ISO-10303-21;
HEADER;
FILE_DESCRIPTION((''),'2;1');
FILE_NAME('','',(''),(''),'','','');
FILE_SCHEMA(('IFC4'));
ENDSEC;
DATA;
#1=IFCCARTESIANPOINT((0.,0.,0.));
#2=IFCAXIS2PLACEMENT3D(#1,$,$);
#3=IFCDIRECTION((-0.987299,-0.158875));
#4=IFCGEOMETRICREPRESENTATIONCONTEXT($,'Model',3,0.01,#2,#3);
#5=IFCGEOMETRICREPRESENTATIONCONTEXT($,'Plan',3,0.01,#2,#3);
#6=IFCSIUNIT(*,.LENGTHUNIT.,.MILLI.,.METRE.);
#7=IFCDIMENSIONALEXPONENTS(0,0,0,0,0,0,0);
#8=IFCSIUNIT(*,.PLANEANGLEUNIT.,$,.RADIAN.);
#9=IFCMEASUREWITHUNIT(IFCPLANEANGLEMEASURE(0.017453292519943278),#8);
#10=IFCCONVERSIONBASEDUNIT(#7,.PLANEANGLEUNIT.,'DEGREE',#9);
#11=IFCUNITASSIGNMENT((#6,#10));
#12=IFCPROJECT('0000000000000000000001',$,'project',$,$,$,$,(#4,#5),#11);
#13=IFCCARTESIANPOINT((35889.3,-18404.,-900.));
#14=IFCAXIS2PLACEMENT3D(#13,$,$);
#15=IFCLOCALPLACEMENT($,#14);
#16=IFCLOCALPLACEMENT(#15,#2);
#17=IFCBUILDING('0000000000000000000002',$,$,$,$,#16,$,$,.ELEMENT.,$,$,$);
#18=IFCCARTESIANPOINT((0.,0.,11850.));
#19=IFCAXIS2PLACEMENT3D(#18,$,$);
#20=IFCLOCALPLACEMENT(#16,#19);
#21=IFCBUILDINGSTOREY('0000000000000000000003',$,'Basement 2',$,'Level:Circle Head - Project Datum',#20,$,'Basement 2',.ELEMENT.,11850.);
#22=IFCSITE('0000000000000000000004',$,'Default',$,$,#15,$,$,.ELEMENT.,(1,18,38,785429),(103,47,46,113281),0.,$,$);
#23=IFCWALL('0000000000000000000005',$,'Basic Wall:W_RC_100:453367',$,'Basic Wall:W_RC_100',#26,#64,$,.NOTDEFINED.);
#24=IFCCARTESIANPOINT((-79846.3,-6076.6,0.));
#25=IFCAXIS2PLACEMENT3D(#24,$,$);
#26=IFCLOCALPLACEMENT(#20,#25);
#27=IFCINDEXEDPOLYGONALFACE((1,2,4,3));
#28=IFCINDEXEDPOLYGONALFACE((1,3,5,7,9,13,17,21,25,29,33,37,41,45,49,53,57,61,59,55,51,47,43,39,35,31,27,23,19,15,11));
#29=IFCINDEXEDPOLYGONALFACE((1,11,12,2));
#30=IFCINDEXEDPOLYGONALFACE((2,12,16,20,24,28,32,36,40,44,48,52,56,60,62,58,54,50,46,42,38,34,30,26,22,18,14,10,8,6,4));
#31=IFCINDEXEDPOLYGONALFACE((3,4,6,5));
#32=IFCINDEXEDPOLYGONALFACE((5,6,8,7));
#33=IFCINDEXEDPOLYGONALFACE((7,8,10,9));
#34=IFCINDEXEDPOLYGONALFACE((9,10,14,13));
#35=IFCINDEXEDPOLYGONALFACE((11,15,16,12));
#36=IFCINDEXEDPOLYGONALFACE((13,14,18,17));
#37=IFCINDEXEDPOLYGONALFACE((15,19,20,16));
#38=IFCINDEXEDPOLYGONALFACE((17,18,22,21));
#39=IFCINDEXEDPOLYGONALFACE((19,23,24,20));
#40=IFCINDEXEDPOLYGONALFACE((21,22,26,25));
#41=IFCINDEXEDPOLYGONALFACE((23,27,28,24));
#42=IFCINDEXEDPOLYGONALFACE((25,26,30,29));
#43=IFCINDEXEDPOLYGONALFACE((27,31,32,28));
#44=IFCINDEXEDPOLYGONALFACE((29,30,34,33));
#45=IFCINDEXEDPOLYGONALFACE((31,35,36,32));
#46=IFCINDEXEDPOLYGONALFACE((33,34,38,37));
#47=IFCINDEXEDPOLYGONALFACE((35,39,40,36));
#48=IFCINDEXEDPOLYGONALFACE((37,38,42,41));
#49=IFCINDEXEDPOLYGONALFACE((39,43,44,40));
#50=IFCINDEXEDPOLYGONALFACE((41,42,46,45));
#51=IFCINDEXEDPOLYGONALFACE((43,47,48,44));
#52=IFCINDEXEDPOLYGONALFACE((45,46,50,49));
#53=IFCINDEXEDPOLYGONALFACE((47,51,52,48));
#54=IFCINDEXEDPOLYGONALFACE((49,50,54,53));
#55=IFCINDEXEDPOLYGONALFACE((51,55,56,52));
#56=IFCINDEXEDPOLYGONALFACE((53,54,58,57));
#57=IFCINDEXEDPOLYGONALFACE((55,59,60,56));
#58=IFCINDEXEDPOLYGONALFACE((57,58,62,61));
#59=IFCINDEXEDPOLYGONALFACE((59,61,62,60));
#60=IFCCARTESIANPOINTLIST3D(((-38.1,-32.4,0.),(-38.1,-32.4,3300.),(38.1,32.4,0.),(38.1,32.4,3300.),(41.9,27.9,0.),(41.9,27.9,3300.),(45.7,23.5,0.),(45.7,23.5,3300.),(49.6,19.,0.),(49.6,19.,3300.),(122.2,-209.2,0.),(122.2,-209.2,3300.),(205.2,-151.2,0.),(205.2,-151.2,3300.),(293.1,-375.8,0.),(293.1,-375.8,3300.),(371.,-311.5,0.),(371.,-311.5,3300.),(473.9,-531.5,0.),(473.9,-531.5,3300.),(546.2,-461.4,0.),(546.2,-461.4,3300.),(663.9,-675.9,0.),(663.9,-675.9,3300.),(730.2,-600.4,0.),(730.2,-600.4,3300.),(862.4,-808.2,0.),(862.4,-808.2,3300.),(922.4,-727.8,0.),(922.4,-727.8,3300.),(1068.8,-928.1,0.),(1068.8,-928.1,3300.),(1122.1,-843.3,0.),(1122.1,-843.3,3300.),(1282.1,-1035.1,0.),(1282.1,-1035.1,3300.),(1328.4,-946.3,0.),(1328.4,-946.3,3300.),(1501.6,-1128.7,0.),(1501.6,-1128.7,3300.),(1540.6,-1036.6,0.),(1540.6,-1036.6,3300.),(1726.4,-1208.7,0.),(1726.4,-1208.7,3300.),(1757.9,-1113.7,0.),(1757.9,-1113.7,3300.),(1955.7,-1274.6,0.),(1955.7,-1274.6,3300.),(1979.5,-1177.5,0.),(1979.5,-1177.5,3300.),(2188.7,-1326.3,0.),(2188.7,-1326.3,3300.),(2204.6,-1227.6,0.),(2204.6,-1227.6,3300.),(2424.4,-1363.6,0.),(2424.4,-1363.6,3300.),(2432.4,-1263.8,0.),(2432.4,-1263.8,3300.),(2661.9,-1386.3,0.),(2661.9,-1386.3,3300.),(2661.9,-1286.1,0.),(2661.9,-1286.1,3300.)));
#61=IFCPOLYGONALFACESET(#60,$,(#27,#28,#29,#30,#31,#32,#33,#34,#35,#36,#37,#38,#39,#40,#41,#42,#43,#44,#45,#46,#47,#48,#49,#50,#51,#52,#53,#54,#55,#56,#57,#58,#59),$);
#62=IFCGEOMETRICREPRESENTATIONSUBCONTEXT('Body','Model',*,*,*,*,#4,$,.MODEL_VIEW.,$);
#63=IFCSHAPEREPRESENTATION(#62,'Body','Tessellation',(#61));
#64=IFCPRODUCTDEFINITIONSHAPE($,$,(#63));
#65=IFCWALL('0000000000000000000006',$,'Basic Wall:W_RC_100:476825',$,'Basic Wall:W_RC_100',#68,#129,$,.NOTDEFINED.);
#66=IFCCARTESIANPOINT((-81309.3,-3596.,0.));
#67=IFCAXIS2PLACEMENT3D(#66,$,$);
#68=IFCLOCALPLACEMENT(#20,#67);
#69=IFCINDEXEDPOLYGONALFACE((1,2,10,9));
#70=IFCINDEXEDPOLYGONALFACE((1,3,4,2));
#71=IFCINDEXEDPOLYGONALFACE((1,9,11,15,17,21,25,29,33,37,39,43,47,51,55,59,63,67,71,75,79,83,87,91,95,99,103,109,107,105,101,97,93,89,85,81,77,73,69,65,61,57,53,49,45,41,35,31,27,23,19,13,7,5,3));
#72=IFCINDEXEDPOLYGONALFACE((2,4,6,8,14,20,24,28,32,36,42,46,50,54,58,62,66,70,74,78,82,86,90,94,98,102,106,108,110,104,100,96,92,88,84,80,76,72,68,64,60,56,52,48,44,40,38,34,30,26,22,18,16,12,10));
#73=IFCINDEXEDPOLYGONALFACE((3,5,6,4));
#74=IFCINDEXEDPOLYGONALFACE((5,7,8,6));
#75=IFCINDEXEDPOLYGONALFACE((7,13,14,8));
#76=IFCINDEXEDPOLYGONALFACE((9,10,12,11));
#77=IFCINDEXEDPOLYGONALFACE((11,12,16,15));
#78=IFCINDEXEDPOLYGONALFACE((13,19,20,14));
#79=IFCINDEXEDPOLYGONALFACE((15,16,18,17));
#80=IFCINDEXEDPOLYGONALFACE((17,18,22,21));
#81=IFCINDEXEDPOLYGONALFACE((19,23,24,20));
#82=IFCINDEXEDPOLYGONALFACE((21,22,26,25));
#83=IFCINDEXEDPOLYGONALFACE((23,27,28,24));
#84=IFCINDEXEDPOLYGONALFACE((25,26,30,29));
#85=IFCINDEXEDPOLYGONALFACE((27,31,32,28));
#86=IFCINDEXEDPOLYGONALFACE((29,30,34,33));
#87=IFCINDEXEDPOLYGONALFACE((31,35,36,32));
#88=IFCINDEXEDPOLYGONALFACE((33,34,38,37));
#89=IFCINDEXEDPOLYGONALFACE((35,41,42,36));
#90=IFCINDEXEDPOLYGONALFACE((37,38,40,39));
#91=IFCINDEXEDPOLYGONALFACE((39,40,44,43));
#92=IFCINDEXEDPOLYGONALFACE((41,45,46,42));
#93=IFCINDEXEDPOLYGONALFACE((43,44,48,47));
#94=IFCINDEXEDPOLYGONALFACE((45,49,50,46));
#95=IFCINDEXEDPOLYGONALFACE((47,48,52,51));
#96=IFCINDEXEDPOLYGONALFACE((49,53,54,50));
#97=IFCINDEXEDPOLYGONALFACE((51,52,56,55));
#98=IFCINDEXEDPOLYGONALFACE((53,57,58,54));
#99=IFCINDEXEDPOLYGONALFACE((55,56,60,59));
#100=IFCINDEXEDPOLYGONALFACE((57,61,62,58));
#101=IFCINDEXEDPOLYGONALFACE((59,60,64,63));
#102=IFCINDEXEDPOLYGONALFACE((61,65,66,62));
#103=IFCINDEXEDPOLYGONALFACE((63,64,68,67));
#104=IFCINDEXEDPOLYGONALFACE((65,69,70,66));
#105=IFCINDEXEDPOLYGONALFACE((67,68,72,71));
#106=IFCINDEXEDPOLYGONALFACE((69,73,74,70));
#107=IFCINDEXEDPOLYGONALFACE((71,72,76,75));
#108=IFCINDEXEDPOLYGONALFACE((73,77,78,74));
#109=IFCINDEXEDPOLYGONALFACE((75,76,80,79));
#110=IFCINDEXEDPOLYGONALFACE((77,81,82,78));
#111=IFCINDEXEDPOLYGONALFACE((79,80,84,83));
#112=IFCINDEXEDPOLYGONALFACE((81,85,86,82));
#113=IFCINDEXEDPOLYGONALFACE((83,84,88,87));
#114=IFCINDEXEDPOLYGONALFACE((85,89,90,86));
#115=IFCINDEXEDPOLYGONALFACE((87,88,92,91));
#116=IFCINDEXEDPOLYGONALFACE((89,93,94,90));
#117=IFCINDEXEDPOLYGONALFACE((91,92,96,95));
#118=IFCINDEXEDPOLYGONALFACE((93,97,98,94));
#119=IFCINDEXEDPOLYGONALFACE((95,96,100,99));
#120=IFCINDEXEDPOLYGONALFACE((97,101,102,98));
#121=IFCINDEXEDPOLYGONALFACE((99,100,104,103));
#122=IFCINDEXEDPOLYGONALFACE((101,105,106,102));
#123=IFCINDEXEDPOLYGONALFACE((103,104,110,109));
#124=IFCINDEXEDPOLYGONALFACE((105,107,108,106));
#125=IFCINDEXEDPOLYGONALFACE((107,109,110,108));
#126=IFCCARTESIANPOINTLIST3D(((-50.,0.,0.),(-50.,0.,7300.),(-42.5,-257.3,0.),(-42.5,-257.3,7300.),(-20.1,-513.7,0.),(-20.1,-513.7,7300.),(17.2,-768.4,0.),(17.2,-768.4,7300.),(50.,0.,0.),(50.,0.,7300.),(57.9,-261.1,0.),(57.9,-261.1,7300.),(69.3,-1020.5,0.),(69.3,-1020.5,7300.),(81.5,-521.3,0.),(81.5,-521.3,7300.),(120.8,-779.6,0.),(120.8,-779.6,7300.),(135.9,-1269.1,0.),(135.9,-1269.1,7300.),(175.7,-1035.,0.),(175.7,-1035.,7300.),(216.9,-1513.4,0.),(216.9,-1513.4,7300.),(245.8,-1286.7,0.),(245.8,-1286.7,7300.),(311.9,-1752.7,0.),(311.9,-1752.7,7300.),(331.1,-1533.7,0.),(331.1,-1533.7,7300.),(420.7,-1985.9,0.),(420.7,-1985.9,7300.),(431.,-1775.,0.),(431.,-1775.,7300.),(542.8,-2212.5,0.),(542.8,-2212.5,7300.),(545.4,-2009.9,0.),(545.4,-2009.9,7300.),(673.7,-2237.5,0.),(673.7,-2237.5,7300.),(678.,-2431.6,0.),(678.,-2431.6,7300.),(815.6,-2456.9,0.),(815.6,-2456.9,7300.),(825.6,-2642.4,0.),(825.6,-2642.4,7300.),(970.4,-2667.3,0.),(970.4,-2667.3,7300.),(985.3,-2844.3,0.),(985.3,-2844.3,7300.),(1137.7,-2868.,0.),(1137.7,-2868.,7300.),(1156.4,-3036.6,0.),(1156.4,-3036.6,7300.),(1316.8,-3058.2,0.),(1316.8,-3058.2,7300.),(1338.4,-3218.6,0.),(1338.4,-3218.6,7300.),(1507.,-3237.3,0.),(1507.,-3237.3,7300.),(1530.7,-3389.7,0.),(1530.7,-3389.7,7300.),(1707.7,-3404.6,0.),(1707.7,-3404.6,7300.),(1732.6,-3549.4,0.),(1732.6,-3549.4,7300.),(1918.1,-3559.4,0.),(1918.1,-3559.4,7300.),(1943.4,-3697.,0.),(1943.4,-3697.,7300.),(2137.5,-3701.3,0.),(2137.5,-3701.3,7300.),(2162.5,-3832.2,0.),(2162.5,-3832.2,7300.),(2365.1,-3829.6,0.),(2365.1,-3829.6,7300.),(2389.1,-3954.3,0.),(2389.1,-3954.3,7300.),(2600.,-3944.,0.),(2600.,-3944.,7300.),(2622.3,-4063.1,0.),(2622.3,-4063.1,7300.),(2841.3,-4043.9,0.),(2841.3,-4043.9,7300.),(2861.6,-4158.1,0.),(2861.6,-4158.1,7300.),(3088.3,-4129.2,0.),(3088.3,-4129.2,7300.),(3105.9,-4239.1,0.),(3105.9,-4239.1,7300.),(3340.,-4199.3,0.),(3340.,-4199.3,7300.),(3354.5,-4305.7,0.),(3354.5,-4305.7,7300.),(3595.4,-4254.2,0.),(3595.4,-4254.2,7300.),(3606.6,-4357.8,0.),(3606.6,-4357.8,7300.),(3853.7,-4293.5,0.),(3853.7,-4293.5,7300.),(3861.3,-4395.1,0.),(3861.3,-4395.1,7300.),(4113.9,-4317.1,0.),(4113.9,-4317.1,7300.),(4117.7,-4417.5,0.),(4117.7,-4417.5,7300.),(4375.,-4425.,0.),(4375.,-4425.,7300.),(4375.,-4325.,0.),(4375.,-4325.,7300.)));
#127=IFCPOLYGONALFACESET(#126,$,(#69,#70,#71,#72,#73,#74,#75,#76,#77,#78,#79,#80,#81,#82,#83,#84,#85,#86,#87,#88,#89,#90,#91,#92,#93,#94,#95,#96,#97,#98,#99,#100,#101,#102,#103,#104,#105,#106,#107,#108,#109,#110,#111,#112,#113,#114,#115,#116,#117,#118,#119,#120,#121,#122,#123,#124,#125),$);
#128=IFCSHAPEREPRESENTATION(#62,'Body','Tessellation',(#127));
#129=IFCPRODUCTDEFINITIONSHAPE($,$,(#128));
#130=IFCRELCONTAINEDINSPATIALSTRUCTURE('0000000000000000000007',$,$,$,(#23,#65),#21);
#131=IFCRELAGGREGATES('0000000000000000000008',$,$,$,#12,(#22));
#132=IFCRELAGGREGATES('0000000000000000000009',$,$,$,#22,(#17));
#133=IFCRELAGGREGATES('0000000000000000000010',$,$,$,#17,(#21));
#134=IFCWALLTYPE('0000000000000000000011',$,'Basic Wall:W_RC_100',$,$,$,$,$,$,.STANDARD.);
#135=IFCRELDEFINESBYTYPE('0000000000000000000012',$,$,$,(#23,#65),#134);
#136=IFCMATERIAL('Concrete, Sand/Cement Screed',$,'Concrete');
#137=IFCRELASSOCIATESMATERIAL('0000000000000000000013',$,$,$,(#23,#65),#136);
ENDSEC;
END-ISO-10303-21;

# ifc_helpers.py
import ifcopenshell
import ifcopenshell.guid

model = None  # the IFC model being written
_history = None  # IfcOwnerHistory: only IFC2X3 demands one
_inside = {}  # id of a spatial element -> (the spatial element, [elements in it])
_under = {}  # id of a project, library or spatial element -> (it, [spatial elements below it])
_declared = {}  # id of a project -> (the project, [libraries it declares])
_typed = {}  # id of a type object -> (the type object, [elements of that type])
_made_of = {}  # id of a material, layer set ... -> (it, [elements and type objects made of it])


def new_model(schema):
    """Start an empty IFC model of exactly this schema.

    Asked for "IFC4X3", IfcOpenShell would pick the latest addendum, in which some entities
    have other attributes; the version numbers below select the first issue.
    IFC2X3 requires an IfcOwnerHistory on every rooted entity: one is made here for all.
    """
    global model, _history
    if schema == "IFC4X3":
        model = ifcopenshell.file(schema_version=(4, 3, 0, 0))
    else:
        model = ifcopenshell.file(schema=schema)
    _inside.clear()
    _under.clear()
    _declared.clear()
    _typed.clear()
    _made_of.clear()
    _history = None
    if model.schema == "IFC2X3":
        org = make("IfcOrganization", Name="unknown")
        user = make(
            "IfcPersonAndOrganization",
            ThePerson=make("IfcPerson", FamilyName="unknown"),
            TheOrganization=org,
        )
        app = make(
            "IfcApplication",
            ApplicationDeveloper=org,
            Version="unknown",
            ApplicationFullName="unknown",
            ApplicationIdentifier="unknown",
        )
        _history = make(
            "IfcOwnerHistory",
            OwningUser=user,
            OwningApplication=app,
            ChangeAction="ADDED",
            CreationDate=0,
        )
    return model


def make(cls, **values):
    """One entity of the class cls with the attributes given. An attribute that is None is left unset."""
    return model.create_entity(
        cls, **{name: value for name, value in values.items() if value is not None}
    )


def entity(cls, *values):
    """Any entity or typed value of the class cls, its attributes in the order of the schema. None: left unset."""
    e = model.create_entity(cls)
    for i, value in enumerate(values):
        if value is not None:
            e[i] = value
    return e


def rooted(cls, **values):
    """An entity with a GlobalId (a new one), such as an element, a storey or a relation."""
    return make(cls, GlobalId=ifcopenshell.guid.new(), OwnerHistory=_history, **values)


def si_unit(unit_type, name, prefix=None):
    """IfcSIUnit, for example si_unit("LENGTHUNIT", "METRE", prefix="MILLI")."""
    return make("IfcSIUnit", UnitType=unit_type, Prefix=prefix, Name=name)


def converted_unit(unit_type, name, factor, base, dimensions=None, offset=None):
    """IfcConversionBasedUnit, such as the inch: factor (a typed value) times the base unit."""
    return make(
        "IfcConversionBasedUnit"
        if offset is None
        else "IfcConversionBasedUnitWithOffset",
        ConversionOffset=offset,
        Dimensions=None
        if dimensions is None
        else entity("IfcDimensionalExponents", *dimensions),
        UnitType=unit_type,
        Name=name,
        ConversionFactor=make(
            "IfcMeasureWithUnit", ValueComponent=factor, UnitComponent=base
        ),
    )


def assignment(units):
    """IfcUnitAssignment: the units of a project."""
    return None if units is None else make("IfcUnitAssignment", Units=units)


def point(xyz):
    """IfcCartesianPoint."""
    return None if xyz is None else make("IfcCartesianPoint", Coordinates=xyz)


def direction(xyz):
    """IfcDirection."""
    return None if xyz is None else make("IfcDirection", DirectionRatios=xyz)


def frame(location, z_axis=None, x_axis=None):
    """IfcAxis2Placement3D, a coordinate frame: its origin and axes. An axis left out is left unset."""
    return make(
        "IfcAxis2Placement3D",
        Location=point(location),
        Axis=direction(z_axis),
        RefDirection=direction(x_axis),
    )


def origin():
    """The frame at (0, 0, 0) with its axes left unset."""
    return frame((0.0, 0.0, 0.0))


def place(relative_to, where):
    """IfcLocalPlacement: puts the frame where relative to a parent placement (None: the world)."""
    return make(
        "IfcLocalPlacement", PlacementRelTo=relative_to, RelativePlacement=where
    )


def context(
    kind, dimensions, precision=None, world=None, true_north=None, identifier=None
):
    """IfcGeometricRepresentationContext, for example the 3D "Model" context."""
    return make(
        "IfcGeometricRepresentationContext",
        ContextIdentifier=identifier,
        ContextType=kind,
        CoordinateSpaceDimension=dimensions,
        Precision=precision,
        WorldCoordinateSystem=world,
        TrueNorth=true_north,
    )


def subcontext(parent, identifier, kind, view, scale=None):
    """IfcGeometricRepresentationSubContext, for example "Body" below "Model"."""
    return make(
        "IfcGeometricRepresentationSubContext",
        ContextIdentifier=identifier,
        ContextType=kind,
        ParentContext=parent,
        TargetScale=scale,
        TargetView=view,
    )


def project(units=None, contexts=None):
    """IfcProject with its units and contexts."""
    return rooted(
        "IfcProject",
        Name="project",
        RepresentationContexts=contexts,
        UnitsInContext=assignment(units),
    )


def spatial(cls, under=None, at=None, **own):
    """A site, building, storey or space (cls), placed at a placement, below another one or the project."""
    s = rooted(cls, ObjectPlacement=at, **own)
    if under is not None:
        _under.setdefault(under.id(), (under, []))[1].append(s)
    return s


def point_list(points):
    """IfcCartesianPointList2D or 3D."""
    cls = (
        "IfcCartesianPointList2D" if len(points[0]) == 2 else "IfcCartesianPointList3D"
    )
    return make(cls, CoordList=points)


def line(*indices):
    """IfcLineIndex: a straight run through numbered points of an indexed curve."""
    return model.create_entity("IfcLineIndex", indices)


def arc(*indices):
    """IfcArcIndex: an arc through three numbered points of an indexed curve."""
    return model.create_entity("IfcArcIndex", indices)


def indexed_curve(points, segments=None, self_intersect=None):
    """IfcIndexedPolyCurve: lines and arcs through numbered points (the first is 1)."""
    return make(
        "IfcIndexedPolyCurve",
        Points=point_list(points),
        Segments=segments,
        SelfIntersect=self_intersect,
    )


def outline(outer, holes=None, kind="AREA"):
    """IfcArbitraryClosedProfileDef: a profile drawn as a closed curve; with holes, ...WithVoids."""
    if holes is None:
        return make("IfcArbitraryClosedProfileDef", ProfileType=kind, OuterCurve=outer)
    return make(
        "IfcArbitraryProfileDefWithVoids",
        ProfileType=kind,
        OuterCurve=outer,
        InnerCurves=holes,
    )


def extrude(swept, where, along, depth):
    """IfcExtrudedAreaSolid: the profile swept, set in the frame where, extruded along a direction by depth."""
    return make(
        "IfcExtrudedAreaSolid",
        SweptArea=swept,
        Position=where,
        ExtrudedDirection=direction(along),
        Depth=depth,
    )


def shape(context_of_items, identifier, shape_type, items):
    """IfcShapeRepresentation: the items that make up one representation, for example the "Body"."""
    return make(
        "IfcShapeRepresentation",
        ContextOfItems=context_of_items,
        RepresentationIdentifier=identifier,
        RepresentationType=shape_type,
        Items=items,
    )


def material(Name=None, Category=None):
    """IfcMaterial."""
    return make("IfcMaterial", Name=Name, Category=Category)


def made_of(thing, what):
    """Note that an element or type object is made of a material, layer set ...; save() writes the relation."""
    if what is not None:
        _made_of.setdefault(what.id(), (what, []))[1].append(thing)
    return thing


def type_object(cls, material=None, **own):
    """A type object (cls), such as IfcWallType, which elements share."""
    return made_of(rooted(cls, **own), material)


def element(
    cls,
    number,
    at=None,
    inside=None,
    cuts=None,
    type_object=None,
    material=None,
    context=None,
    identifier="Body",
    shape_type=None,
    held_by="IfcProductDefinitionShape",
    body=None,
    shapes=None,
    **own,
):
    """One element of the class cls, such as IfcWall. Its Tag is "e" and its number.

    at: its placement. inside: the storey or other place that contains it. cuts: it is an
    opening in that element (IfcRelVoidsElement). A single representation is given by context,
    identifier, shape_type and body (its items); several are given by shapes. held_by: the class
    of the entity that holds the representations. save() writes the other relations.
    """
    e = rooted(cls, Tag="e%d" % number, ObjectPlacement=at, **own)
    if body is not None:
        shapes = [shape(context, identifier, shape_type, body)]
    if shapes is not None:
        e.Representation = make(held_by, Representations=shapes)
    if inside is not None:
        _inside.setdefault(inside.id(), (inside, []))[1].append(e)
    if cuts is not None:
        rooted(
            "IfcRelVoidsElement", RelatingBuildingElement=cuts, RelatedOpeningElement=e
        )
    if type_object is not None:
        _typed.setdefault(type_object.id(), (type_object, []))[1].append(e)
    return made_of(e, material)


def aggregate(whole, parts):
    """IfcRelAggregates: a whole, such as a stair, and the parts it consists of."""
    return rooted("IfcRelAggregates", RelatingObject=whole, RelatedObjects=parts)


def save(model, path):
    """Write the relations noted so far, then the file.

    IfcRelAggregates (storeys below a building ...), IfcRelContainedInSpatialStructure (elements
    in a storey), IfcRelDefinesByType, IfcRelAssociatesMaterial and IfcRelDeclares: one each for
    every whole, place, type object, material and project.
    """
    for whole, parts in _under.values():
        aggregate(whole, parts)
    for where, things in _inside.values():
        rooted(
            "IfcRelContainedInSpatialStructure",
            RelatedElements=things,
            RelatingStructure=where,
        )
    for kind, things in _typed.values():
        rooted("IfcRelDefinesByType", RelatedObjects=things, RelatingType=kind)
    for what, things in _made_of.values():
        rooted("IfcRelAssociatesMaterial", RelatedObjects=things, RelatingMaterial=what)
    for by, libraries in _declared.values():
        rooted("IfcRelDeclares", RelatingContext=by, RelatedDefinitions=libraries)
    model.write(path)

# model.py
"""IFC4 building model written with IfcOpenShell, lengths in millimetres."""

from ifc_helpers import new_model, entity, si_unit, converted_unit, direction, frame, origin, place, context, subcontext, project, spatial, line, arc, indexed_curve, outline, extrude, material, type_object, element, save


model = new_model("IFC4")

# Units and contexts
model_context = context("Model", 3, precision=0.01, world=origin(), true_north=direction((-0.987299, -0.158875)))
plan_context = context("Plan", 3, precision=0.01, world=origin(), true_north=direction((-0.987299, -0.158875)))
body_context = subcontext(model_context, "Body", "Model", "MODEL_VIEW")
ifc_project = project(units=[si_unit("LENGTHUNIT", "METRE", prefix="MILLI"), converted_unit("PLANEANGLEUNIT", "DEGREE", entity("IfcPlaneAngleMeasure", 0.017453292519943278), si_unit("PLANEANGLEUNIT", "RADIAN"), dimensions=[0, 0, 0, 0, 0, 0, 0])], contexts=[model_context, plan_context])

# Site, building, storey
site_placement = place(None, frame((35889.3, -18404.0, -900.0)))
site = spatial("IfcSite", under=ifc_project, at=site_placement, Name="Default", CompositionType="ELEMENT", RefLatitude=(1, 18, 38, 785429), RefLongitude=(103, 47, 46, 113281), RefElevation=0.0)
building_placement = place(site_placement, origin())
building = spatial("IfcBuilding", under=site, at=building_placement, CompositionType="ELEMENT")
storey_placement = place(building_placement, frame((0.0, 0.0, 11850.0)))
storey = spatial("IfcBuildingStorey", under=building, at=storey_placement, Name="Basement 2", ObjectType="Level:Circle Head - Project Datum", LongName="Basement 2", CompositionType="ELEMENT", Elevation=11850.0)

# Walls
ifc_material_1 = material(Name="Concrete, Sand/Cement Screed", Category="Concrete")
wall_type_1 = type_object("IfcWallType", Name="Basic Wall:W_RC_100", PredefinedType="STANDARD")
wall_1_placement = place(storey_placement, frame((-79846.3, -6076.6, 0.0)))
element("IfcWall", 1, at=wall_1_placement, inside=storey, type_object=wall_type_1, material=ifc_material_1, Name="Basic Wall:W_RC_100:453367", ObjectType="Basic Wall:W_RC_100", PredefinedType="NOTDEFINED", context=body_context, shape_type="SweptSolid", body=[
    extrude(outline(indexed_curve([(2661.9, -1286.1), (1224.4, -896.4), (49.6, 19.0), (43.8, 25.7), (38.1, 32.4), (-38.1, -32.4), (1174.6, -983.2), (2661.9, -1386.3)], segments=[arc(1, 2, 3), arc(3, 4, 5), line(5, 6), arc(6, 7, 8), line(8, 1)], self_intersect=False)), origin(), (0.0, 0.0, 1.0), 3300.0),
])
wall_2_placement = place(storey_placement, frame((-81309.3, -3596.0, 0.0)))
element("IfcWall", 2, at=wall_2_placement, inside=storey, type_object=wall_type_1, material=ifc_material_1, Name="Basic Wall:W_RC_100:476825", ObjectType="Basic Wall:W_RC_100", PredefinedType="NOTDEFINED", context=body_context, shape_type="SweptSolid", body=[
    extrude(outline(indexed_curve([(4375.0, -4325.0), (1316.8, -3058.2), (50.0, 0.0), (-50.0, 0.0), (1246.1, -3128.9), (4375.0, -4425.0)], segments=[arc(1, 2, 3), line(3, 4), arc(4, 5, 6), line(6, 1)], self_intersect=False)), origin(), (0.0, 0.0, 1.0), 7300.0),
])

save(model, "model.ifc")
